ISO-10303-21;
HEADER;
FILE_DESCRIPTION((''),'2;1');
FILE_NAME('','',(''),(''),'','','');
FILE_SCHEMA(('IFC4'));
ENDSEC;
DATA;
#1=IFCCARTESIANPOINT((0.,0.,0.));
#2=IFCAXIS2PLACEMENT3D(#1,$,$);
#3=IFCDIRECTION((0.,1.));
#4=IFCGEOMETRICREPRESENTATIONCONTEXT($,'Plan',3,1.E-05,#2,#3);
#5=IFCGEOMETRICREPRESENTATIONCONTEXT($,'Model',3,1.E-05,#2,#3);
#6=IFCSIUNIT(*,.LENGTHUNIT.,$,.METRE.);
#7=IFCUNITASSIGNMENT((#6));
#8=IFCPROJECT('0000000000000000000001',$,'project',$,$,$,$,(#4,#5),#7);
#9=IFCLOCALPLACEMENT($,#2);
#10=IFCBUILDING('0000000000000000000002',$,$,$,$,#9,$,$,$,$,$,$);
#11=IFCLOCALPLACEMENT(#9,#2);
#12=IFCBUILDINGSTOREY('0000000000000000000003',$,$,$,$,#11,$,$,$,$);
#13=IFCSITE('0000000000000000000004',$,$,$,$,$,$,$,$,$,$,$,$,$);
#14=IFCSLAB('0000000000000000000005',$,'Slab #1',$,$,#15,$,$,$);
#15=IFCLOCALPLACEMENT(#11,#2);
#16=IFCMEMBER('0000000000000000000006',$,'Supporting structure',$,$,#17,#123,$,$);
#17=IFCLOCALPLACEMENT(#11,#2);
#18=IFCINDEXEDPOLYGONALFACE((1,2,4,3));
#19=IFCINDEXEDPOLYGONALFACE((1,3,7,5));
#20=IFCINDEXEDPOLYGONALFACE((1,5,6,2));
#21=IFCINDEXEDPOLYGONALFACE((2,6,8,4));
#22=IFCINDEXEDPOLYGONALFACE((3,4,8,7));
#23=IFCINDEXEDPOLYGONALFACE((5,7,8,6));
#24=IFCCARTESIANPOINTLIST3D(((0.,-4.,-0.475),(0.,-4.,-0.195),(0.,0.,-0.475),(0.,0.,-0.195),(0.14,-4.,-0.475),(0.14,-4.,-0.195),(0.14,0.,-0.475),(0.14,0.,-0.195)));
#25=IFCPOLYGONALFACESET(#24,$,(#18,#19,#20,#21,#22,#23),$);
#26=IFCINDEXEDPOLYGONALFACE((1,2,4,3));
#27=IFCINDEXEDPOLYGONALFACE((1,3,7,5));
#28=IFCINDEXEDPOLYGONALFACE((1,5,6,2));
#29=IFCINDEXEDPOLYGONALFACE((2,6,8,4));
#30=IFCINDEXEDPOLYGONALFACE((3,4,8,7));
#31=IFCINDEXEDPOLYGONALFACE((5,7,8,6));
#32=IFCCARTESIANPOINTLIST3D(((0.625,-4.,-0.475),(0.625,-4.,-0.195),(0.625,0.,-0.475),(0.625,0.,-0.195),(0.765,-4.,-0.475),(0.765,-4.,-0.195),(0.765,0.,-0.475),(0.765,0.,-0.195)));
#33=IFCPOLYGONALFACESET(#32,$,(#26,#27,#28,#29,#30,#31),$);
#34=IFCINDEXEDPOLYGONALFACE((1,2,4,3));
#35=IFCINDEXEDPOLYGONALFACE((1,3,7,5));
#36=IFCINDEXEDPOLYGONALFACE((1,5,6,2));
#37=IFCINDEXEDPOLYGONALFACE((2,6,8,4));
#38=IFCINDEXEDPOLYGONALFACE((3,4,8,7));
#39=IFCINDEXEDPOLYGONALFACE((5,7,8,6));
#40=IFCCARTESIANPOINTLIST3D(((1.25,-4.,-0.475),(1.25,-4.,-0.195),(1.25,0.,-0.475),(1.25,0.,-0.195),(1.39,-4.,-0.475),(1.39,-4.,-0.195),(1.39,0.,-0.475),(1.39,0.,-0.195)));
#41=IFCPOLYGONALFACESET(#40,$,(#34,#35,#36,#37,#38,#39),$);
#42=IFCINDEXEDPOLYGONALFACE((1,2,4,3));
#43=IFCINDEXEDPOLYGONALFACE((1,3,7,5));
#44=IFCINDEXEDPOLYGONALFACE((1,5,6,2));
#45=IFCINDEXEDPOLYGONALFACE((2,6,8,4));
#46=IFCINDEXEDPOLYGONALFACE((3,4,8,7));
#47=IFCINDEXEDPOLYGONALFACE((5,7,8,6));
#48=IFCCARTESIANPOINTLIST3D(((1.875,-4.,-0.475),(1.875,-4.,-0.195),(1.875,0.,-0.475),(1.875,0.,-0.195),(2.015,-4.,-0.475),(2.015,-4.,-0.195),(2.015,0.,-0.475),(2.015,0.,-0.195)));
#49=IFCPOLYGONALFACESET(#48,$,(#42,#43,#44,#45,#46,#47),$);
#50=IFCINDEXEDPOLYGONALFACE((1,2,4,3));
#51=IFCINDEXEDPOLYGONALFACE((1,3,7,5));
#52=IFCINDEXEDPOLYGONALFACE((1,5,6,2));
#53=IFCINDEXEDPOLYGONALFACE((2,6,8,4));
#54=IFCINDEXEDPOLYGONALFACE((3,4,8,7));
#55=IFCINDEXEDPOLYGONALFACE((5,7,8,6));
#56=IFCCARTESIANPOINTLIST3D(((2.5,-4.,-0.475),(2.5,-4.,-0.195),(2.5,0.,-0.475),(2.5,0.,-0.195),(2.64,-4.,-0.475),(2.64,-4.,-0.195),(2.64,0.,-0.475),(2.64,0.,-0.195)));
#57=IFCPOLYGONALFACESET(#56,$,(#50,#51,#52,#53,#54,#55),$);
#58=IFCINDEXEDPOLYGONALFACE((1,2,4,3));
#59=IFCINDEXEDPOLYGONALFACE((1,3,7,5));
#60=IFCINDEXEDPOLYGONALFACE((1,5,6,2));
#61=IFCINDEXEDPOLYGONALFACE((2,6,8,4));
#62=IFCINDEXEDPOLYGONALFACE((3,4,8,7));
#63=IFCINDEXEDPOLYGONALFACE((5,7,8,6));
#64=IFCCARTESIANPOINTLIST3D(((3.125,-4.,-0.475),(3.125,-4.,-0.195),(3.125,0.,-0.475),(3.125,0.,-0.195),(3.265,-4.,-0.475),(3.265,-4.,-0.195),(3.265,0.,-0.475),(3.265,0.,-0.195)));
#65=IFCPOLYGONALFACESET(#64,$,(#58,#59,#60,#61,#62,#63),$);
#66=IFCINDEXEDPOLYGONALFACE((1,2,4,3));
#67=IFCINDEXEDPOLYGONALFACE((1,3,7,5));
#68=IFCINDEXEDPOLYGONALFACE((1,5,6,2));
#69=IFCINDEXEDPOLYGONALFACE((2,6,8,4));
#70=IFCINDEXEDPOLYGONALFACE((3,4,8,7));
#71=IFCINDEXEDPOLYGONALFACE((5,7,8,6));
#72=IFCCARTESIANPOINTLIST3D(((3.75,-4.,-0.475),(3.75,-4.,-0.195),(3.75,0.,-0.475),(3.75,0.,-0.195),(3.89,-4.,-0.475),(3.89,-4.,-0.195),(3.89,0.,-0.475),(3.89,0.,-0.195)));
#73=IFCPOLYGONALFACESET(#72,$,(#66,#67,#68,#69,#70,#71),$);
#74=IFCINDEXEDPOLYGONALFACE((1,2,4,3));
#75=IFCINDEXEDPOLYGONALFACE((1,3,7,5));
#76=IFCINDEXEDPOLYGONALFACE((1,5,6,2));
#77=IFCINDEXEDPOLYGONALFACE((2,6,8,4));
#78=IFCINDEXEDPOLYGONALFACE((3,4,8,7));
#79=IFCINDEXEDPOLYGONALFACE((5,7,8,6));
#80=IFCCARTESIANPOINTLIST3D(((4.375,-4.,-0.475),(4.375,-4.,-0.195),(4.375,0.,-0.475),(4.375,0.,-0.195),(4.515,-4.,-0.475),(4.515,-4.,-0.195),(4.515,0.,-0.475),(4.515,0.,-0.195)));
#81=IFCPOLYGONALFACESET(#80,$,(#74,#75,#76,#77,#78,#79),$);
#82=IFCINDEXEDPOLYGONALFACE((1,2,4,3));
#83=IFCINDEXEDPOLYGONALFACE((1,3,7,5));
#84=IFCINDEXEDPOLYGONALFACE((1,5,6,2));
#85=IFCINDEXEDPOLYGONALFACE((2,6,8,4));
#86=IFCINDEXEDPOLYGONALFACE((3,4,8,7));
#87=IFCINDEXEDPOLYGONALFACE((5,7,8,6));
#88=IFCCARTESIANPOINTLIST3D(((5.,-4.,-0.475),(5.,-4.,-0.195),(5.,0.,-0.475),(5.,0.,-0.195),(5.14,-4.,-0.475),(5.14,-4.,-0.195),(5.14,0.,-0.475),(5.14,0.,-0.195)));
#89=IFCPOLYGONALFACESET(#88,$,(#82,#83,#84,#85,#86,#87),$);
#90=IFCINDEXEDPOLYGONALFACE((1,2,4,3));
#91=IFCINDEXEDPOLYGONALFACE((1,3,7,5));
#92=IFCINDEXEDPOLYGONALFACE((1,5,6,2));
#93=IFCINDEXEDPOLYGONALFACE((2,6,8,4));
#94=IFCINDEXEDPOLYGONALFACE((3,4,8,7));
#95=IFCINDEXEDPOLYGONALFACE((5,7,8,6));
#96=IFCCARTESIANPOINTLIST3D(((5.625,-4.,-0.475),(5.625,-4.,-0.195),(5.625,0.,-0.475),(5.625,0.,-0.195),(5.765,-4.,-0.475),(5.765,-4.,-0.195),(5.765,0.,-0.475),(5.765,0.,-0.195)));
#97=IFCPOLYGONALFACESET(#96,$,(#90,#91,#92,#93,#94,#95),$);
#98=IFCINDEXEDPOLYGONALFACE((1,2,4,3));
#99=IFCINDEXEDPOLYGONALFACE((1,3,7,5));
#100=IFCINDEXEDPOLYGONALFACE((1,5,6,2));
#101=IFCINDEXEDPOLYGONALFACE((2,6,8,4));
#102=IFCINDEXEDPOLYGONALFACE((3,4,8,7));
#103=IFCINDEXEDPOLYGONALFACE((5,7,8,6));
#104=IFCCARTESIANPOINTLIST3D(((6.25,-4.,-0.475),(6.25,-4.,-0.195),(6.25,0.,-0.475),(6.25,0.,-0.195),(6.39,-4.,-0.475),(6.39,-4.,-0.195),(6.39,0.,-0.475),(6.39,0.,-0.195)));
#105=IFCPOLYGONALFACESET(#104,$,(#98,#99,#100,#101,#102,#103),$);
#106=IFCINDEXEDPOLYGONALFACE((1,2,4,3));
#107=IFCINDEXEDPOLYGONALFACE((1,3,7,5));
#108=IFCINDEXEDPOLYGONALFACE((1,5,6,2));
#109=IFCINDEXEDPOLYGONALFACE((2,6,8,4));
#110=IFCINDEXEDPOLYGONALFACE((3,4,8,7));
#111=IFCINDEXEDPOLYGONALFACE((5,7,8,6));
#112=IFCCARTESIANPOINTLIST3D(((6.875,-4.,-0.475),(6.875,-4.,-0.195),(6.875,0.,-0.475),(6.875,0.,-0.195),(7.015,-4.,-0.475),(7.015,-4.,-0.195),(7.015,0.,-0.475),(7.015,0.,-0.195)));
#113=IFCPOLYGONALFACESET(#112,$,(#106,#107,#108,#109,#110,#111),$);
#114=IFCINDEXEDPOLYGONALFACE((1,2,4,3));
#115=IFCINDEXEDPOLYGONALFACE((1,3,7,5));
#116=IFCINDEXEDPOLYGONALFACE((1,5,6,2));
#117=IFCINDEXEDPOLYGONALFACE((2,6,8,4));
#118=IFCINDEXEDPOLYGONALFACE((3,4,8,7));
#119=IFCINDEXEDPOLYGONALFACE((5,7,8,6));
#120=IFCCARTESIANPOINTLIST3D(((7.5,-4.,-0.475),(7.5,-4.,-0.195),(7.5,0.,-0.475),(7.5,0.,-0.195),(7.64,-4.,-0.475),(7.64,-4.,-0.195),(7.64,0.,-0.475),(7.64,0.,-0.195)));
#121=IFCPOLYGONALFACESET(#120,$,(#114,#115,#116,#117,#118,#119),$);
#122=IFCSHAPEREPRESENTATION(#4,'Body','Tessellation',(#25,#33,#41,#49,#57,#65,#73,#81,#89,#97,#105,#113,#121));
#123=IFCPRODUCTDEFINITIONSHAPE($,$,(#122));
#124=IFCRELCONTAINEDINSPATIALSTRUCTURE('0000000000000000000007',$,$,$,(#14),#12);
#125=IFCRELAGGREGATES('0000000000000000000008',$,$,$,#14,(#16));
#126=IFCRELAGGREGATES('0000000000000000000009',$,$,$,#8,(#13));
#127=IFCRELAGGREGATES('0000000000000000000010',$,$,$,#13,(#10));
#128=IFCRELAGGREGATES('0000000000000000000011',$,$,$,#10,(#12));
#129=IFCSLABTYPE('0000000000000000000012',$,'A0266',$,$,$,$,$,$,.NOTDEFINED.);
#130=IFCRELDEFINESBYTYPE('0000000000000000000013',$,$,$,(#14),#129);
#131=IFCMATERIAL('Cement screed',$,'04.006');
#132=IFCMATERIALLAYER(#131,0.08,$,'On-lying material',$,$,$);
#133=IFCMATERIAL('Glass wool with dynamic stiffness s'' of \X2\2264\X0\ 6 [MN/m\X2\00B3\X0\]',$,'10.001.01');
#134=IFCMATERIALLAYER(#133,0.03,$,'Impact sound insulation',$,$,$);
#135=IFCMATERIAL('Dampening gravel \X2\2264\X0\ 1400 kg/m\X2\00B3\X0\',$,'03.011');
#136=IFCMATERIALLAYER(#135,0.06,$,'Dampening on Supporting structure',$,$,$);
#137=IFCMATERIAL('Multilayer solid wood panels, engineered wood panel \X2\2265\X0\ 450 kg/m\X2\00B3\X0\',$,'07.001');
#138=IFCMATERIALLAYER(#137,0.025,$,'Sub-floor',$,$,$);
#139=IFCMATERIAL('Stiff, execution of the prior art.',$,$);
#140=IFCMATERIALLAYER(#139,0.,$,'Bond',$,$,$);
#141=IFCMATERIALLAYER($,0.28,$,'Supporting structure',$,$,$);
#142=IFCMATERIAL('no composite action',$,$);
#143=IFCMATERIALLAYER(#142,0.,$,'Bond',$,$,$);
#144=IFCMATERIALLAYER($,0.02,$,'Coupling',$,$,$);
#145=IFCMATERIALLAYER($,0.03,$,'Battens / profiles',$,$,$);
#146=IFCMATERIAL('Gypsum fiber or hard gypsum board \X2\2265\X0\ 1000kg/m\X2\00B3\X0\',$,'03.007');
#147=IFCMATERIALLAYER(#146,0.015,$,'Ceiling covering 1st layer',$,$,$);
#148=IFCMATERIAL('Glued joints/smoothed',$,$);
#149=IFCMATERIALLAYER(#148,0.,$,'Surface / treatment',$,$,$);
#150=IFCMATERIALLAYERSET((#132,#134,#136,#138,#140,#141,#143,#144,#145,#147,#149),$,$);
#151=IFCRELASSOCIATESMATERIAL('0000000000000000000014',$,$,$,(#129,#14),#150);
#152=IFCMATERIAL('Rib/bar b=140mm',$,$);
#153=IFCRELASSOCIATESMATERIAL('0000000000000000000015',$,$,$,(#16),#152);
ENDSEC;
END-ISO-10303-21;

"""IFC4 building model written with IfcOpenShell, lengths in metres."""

from ifc_helpers import new_model, si_unit, direction, frame, frame_2d, origin, place, context, project, spatial, rectangle, extrude, material, layer, layer_set, type_object, element, aggregate, save


model = new_model("IFC4")

# Units and contexts
plan_context = context("Plan", 3, precision=1e-05, world=origin(), true_north=direction((0.0, 1.0)))
model_context = context("Model", 3, precision=1e-05, world=origin(), true_north=direction((0.0, 1.0)))
ifc_project = project(units=[si_unit("LENGTHUNIT", "METRE")], contexts=[plan_context, model_context])

# Site, building, storey
site = spatial("IfcSite", under=ifc_project)
building_placement = place(None, origin())
building = spatial("IfcBuilding", under=site, at=building_placement)
storey_placement = place(building_placement, origin())
storey = spatial("IfcBuildingStorey", under=building, at=storey_placement)

# Slab, member
ifc_material_1 = material(Name="Cement screed", Category="04.006")
ifc_layer_1 = layer(ifc_material_1, 0.08, Name="On-lying material")
ifc_material_2 = material(Name="Glass wool with dynamic stiffness s' of ≤ 6 [MN/m³]", Category="10.001.01")
ifc_layer_2 = layer(ifc_material_2, 0.03, Name="Impact sound insulation")
ifc_material_3 = material(Name="Dampening gravel ≤ 1400 kg/m³", Category="03.011")
ifc_layer_3 = layer(ifc_material_3, 0.06, Name="Dampening on Supporting structure")
ifc_material_4 = material(Name="Multilayer solid wood panels, engineered wood panel ≥ 450 kg/m³", Category="07.001")
ifc_layer_4 = layer(ifc_material_4, 0.025, Name="Sub-floor")
ifc_material_5 = material(Name="Stiff, execution of the prior art.")
ifc_layer_5 = layer(ifc_material_5, 0.0, Name="Bond")
ifc_layer_6 = layer(None, 0.28, Name="Supporting structure")
ifc_material_6 = material(Name="no composite action")
ifc_layer_7 = layer(ifc_material_6, 0.0, Name="Bond")
ifc_layer_8 = layer(None, 0.02, Name="Coupling")
ifc_layer_9 = layer(None, 0.03, Name="Battens / profiles")
ifc_material_7 = material(Name="Gypsum fiber or hard gypsum board ≥ 1000kg/m³", Category="03.007")
ifc_layer_10 = layer(ifc_material_7, 0.015, Name="Ceiling covering 1st layer")
ifc_material_8 = material(Name="Glued joints/smoothed")
ifc_layer_11 = layer(ifc_material_8, 0.0, Name="Surface / treatment")
ifc_layer_set = layer_set([ifc_layer_1, ifc_layer_2, ifc_layer_3, ifc_layer_4, ifc_layer_5, ifc_layer_6, ifc_layer_7, ifc_layer_8, ifc_layer_9, ifc_layer_10, ifc_layer_11])
slab_type = type_object("IfcSlabType", Name="A0266", PredefinedType="NOTDEFINED", material=ifc_layer_set)
slab_placement = place(None, frame((0.0, 0.0, 0.0), z_axis=(0.0, 0.0, -1.0), x_axis=(1.0, 0.0, 0.0)))
slab = element("IfcSlab", 1, at=slab_placement, inside=storey, type_object=slab_type, material=ifc_layer_set, Name="Slab #1")
ifc_material_9 = material(Name="Rib/bar b=140mm")
member_1_placement = place(slab_placement, origin())
member_1 = element("IfcMember", 2, at=member_1_placement, material=ifc_material_9, Name="Supporting structure", context=plan_context, shape_type="SweptSolid", body=[
    extrude(rectangle(XDim=0.14, YDim=0.28, at=frame_2d((0.07, 0.14), x_axis=(1.0, 0.0))), frame((0.0, 4.0, 0.195), z_axis=(0.0, -1.0, 0.0), x_axis=(1.0, 0.0, 0.0)), (0.0, 0.0, 1.0), 4.0),
    extrude(rectangle(XDim=0.14, YDim=0.28, at=frame_2d((0.07, 0.14), x_axis=(1.0, 0.0))), frame((0.625, 4.0, 0.195), z_axis=(0.0, -1.0, 0.0), x_axis=(1.0, 0.0, 0.0)), (0.0, 0.0, 1.0), 4.0),
    extrude(rectangle(XDim=0.14, YDim=0.28, at=frame_2d((0.07, 0.14), x_axis=(1.0, 0.0))), frame((1.25, 4.0, 0.195), z_axis=(0.0, -1.0, 0.0), x_axis=(1.0, 0.0, 0.0)), (0.0, 0.0, 1.0), 4.0),
    extrude(rectangle(XDim=0.14, YDim=0.28, at=frame_2d((0.07, 0.14), x_axis=(1.0, 0.0))), frame((1.875, 4.0, 0.195), z_axis=(0.0, -1.0, 0.0), x_axis=(1.0, 0.0, 0.0)), (0.0, 0.0, 1.0), 4.0),
    extrude(rectangle(XDim=0.14, YDim=0.28, at=frame_2d((0.07, 0.14), x_axis=(1.0, 0.0))), frame((2.5, 4.0, 0.195), z_axis=(0.0, -1.0, 0.0), x_axis=(1.0, 0.0, 0.0)), (0.0, 0.0, 1.0), 4.0),
    extrude(rectangle(XDim=0.14, YDim=0.28, at=frame_2d((0.07, 0.14), x_axis=(1.0, 0.0))), frame((3.125, 4.0, 0.195), z_axis=(0.0, -1.0, 0.0), x_axis=(1.0, 0.0, 0.0)), (0.0, 0.0, 1.0), 4.0),
    extrude(rectangle(XDim=0.14, YDim=0.28, at=frame_2d((0.07, 0.14), x_axis=(1.0, 0.0))), frame((3.75, 4.0, 0.195), z_axis=(0.0, -1.0, 0.0), x_axis=(1.0, 0.0, 0.0)), (0.0, 0.0, 1.0), 4.0),
    extrude(rectangle(XDim=0.14, YDim=0.28, at=frame_2d((0.07, 0.14), x_axis=(1.0, 0.0))), frame((4.375, 4.0, 0.195), z_axis=(0.0, -1.0, 0.0), x_axis=(1.0, 0.0, 0.0)), (0.0, 0.0, 1.0), 4.0),
    extrude(rectangle(XDim=0.14, YDim=0.28, at=frame_2d((0.07, 0.14), x_axis=(1.0, 0.0))), frame((5.0, 4.0, 0.195), z_axis=(0.0, -1.0, 0.0), x_axis=(1.0, 0.0, 0.0)), (0.0, 0.0, 1.0), 4.0),
    extrude(rectangle(XDim=0.14, YDim=0.28, at=frame_2d((0.07, 0.14), x_axis=(1.0, 0.0))), frame((5.625, 4.0, 0.195), z_axis=(0.0, -1.0, 0.0), x_axis=(1.0, 0.0, 0.0)), (0.0, 0.0, 1.0), 4.0),
    extrude(rectangle(XDim=0.14, YDim=0.28, at=frame_2d((0.07, 0.14), x_axis=(1.0, 0.0))), frame((6.25, 4.0, 0.195), z_axis=(0.0, -1.0, 0.0), x_axis=(1.0, 0.0, 0.0)), (0.0, 0.0, 1.0), 4.0),
    extrude(rectangle(XDim=0.14, YDim=0.28, at=frame_2d((0.07, 0.14), x_axis=(1.0, 0.0))), frame((6.875, 4.0, 0.195), z_axis=(0.0, -1.0, 0.0), x_axis=(1.0, 0.0, 0.0)), (0.0, 0.0, 1.0), 4.0),
    extrude(rectangle(XDim=0.14, YDim=0.28, at=frame_2d((0.07, 0.14), x_axis=(1.0, 0.0))), frame((7.5, 4.0, 0.195), z_axis=(0.0, -1.0, 0.0), x_axis=(1.0, 0.0, 0.0)), (0.0, 0.0, 1.0), 4.0),
])
aggregate(slab, [member_1])

save(model, "model.ifc")
